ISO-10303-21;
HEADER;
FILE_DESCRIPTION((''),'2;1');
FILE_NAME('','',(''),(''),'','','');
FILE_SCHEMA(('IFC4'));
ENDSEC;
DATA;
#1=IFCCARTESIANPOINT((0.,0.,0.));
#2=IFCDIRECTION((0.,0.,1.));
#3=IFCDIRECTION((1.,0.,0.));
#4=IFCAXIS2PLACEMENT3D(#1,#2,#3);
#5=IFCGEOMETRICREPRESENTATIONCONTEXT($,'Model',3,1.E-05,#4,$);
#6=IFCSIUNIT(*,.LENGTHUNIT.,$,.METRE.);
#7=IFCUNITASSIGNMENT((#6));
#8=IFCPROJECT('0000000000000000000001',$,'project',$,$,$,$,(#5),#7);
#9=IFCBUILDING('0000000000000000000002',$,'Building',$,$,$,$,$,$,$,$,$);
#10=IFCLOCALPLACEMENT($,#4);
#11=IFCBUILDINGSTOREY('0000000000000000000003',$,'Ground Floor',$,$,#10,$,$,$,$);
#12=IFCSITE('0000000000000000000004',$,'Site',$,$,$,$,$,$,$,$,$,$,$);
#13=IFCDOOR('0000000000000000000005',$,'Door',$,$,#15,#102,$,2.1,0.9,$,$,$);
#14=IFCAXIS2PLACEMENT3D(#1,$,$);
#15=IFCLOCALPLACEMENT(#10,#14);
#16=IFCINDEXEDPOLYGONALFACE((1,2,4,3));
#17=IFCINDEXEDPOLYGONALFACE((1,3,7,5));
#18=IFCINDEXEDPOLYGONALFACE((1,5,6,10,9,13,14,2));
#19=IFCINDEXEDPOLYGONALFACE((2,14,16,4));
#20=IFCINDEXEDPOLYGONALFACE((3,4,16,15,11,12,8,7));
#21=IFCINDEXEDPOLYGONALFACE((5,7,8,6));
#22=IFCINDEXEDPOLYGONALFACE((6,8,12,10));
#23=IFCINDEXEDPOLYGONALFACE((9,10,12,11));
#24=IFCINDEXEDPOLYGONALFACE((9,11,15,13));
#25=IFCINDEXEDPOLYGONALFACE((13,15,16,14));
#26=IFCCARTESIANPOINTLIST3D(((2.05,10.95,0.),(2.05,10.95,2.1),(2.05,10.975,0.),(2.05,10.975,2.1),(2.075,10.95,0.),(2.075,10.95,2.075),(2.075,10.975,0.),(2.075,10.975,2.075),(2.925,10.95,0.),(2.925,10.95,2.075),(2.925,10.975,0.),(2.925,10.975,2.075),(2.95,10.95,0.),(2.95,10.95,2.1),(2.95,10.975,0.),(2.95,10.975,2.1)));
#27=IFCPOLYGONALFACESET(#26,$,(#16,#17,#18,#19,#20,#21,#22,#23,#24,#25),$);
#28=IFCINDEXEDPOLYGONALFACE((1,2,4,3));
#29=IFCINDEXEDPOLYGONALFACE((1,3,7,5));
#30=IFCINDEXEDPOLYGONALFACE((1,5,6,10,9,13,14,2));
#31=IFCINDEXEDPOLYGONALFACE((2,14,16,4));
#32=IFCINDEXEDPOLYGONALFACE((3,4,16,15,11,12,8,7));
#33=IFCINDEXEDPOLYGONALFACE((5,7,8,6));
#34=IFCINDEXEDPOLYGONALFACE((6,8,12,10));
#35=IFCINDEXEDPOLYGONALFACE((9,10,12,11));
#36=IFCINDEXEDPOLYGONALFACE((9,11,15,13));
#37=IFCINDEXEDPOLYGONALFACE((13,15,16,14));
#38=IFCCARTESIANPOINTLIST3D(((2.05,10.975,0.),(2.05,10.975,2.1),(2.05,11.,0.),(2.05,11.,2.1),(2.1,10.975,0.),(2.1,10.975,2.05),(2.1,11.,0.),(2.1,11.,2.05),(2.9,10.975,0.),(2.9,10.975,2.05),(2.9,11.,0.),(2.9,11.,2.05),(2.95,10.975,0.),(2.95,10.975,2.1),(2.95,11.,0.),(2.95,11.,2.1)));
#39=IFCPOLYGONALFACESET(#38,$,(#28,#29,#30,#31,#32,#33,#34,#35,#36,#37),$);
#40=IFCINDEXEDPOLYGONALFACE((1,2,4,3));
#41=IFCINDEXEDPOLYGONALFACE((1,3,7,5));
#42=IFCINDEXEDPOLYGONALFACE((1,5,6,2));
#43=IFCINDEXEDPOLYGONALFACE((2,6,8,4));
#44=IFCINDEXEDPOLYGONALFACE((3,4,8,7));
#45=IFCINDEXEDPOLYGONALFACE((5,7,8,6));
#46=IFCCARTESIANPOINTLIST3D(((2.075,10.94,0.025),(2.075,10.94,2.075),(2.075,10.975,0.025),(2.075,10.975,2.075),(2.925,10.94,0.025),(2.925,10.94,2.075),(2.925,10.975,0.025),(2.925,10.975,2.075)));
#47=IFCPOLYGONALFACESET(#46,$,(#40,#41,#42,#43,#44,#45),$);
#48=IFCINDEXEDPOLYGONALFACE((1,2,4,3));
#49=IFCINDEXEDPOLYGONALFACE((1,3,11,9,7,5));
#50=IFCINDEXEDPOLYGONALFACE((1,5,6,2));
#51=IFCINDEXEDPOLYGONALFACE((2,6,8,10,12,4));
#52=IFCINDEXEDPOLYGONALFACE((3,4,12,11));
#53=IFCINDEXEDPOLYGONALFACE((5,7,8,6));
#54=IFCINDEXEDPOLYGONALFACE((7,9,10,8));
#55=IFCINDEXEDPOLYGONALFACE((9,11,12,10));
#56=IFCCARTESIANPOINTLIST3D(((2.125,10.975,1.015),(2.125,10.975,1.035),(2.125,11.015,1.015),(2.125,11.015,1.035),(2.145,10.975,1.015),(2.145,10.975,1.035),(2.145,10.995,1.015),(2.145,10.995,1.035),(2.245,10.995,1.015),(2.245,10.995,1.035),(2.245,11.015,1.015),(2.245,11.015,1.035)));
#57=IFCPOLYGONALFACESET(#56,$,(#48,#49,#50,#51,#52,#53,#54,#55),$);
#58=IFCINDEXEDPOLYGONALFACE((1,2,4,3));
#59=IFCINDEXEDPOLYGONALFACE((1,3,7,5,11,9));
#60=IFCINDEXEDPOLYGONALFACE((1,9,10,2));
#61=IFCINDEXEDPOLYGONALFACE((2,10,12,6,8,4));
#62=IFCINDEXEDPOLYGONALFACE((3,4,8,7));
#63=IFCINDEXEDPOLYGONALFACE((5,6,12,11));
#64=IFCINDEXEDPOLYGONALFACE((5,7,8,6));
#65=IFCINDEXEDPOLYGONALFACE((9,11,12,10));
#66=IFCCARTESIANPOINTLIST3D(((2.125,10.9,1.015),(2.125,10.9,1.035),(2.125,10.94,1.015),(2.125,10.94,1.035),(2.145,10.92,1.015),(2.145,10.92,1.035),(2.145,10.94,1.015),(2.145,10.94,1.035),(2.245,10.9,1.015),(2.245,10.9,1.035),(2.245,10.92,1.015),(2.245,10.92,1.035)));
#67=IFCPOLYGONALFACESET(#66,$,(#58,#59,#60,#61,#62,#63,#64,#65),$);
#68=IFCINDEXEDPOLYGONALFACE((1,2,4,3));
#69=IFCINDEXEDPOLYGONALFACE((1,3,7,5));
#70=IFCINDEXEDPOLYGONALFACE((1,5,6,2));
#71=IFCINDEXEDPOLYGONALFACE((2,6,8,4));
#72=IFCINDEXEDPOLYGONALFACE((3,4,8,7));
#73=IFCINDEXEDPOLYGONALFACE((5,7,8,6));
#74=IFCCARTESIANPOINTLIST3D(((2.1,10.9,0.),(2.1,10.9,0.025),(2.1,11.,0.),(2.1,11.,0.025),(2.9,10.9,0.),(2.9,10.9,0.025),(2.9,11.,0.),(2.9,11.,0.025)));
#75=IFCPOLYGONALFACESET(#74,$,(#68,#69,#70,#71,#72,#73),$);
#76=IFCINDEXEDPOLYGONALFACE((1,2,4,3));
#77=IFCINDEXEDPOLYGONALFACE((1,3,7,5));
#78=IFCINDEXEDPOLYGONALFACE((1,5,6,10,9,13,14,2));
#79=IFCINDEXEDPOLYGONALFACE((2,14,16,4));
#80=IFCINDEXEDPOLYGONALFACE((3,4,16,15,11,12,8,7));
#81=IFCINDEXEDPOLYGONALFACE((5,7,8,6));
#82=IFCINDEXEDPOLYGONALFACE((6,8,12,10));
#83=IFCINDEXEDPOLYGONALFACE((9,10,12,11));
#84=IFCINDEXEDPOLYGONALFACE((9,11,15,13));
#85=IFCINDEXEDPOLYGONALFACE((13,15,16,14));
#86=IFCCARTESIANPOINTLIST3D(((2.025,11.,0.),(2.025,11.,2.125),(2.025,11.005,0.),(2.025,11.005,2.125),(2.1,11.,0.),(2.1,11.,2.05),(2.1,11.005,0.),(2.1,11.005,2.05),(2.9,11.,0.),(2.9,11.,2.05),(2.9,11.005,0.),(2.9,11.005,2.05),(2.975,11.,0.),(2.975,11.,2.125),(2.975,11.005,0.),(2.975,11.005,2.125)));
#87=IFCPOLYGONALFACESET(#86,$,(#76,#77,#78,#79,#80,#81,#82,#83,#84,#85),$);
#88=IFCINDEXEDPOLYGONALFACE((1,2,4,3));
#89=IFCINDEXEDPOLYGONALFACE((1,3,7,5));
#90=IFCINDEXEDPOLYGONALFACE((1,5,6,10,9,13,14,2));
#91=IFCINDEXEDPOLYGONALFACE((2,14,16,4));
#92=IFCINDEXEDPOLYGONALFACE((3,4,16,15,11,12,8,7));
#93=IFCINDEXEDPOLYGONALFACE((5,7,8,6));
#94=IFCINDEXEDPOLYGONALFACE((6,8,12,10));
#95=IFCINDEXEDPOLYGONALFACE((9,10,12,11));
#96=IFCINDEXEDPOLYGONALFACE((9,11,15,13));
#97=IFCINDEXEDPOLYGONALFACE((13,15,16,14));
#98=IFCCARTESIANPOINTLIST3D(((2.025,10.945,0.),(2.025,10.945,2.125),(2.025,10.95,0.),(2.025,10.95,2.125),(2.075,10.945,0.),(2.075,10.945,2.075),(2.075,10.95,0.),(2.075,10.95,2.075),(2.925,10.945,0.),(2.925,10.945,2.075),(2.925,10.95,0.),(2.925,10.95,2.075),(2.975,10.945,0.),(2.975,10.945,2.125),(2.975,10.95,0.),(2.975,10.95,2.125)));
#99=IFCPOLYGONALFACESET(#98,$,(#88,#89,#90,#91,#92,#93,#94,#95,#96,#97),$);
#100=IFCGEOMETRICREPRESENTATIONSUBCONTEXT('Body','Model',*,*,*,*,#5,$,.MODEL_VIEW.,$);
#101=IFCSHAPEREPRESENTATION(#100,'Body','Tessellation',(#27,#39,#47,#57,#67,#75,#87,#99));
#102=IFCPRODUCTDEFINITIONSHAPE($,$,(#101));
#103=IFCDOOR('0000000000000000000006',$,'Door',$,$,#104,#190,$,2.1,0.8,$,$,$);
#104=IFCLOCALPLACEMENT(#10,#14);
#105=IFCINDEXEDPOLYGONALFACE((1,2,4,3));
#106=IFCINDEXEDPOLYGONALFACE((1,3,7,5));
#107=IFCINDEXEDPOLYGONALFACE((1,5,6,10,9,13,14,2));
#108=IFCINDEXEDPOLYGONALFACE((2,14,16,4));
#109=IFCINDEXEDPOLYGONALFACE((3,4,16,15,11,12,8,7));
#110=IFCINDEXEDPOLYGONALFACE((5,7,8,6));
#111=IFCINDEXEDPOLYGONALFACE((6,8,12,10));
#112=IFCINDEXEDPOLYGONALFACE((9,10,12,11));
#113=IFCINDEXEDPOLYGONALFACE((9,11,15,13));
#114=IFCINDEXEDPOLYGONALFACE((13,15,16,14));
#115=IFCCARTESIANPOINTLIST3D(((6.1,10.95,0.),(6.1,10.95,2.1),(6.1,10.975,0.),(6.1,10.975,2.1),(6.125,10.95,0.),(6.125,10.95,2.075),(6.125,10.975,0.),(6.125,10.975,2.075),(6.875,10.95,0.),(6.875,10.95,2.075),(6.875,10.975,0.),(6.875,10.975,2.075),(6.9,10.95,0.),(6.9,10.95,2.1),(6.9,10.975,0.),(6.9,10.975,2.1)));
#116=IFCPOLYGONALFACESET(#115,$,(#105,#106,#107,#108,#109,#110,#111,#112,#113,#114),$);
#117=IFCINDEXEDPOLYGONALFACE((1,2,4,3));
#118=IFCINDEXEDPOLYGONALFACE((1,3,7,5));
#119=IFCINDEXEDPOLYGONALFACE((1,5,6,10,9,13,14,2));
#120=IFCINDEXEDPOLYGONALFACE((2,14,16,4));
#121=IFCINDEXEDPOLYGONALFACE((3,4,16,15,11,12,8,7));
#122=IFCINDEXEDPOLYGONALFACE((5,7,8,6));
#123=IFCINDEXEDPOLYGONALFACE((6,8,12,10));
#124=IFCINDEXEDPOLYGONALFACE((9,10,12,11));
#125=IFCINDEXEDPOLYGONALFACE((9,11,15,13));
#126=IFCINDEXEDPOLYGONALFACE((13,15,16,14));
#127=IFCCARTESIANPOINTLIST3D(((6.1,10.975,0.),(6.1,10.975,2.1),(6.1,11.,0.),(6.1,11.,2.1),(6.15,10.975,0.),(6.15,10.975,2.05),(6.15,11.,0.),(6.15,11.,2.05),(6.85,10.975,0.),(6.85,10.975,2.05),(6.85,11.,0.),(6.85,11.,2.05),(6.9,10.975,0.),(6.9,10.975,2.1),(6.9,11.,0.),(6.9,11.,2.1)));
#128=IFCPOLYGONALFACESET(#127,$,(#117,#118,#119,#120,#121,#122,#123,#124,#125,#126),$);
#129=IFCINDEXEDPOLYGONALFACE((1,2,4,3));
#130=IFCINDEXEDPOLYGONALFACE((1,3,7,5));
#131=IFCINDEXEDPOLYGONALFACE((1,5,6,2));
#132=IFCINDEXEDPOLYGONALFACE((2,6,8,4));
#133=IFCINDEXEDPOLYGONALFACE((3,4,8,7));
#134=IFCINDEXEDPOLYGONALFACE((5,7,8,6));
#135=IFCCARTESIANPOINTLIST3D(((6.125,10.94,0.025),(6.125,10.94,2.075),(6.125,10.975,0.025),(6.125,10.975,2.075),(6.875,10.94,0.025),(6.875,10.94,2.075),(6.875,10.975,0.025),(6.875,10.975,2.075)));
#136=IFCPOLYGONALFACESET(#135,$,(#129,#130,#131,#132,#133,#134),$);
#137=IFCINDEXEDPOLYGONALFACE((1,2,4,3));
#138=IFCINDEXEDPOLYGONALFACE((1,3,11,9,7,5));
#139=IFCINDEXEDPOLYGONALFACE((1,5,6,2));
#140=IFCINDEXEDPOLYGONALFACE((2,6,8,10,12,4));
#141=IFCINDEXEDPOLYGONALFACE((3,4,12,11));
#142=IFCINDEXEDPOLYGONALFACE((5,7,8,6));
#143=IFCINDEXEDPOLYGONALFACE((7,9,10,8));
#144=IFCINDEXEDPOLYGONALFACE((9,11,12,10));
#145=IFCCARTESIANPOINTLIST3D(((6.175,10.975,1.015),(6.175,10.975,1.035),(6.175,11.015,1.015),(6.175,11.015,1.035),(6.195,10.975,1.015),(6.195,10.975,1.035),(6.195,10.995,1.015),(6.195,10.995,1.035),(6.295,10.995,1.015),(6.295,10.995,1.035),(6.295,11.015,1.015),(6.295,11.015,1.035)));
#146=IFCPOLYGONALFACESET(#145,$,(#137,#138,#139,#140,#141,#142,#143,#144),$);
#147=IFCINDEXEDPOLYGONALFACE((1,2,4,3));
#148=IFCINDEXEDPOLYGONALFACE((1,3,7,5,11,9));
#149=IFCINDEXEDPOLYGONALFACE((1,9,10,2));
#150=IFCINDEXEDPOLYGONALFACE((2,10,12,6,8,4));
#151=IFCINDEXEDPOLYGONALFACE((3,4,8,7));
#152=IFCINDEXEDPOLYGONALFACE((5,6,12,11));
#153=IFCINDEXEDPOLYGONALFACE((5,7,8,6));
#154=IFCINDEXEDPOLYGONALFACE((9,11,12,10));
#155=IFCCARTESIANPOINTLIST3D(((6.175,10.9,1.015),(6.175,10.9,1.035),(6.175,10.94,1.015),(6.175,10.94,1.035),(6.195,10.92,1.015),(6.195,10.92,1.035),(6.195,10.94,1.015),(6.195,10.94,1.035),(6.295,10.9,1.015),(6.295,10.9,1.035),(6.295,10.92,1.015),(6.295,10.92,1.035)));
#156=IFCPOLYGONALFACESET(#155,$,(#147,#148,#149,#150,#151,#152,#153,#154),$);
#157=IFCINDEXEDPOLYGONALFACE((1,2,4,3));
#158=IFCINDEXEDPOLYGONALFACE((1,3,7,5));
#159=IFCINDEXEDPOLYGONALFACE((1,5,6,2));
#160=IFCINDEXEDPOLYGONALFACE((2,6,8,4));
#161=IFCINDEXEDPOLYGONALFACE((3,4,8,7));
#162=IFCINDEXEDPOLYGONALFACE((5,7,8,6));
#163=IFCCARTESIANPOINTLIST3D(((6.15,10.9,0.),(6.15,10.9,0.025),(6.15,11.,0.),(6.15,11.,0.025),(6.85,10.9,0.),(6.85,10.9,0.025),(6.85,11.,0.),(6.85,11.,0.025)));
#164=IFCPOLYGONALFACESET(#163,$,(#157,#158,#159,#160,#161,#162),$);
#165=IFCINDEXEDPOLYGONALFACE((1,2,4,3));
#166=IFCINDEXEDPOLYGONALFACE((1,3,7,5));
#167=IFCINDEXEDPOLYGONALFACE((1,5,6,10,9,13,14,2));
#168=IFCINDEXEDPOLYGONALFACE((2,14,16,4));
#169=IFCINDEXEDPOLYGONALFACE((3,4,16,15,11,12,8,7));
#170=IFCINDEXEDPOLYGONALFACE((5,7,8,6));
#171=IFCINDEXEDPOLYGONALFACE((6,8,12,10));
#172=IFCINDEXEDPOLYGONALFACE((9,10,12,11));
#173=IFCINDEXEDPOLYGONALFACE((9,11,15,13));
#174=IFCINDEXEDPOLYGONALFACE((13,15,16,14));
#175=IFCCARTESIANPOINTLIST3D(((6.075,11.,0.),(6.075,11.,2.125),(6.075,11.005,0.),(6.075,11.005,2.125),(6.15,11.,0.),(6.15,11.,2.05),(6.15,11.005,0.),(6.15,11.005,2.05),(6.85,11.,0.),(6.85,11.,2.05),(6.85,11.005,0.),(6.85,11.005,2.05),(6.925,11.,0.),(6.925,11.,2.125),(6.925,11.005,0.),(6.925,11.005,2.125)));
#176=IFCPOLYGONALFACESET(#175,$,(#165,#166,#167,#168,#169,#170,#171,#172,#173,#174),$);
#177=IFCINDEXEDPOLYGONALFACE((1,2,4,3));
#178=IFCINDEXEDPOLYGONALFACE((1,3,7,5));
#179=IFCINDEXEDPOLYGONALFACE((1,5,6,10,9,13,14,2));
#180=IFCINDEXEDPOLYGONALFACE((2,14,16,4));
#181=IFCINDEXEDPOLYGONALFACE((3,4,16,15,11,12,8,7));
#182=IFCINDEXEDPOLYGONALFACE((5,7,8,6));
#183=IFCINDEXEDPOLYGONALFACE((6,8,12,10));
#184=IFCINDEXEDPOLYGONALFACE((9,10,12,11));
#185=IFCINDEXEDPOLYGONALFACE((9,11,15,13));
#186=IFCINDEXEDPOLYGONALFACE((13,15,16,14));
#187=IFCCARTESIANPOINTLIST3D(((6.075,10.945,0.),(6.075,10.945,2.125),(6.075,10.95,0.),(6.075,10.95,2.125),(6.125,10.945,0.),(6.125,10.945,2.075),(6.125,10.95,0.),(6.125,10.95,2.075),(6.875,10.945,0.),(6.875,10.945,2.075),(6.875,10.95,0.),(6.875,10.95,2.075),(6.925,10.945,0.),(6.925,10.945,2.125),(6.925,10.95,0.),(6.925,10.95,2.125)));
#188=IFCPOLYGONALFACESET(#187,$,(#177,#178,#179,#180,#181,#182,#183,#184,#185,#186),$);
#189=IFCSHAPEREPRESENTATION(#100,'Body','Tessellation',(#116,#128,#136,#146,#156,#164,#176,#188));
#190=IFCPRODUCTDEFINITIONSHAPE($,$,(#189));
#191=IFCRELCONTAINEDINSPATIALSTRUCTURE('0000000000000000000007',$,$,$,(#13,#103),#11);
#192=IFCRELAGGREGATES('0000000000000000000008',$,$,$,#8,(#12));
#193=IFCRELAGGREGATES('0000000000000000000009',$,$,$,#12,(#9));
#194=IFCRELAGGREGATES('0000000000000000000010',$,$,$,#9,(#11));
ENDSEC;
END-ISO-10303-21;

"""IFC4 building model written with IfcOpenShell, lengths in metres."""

from ifc_helpers import new_model, si_unit, frame, origin_with_axes, place, context, subcontext, project, spatial, line, indexed_curve, outline, extrude, element, save


model = new_model("IFC4")

# Units and contexts
model_context = context("Model", 3, precision=1e-05, world=origin_with_axes())
body_context = subcontext(model_context, "Body", "Model", "MODEL_VIEW")
ifc_project = project(units=[si_unit("LENGTHUNIT", "METRE")], contexts=[model_context])

# Site, building, storey
site = spatial("IfcSite", under=ifc_project, Name="Site")
building = spatial("IfcBuilding", under=site, Name="Building")
storey_placement = place(None, origin_with_axes())
storey = spatial("IfcBuildingStorey", under=building, at=storey_placement, Name="Ground Floor")

# Doors
door_1_placement = place(storey_placement, frame((2.95, 11.0, 0.0), z_axis=(0.0, 0.0, 1.0), x_axis=(-1.0, 0.0, 0.0)))
element("IfcDoor", 1, at=door_1_placement, inside=storey, Name="Door", OverallHeight=2.1, OverallWidth=0.9, context=body_context, shape_type="SweptSolid", body=[
    extrude(outline(indexed_curve([(0.0, 0.0), (0.0, 2.1), (0.9, 2.1), (0.9, 0.0), (0.875, 0.0), (0.875, 2.075), (0.025, 2.075), (0.025, 0.0)], segments=[line(1, 2, 3, 4, 5, 6, 7, 8, 1)])), frame((0.0, 0.025, 0.0), z_axis=(0.0, -1.0, 0.0), x_axis=(1.0, 0.0, 0.0)), (0.0, 0.0, -1.0), 0.025),
    extrude(outline(indexed_curve([(0.0, 0.0), (0.0, 2.1), (0.9, 2.1), (0.9, 0.0), (0.85, 0.0), (0.85, 2.05), (0.05, 2.05), (0.05, 0.0)], segments=[line(1, 2, 3, 4, 5, 6, 7, 8, 1)])), frame((0.0, 0.0, 0.0), z_axis=(0.0, -1.0, 0.0), x_axis=(1.0, 0.0, 0.0)), (0.0, 0.0, -1.0), 0.025),
    extrude(outline(indexed_curve([(0.0, 0.0), (0.85, 0.0), (0.85, 0.035), (0.0, 0.035)], segments=[line(1, 2, 3, 4, 1)])), frame((0.025, 0.025, 0.025), z_axis=(0.0, 0.0, 1.0), x_axis=(1.0, 0.0, 0.0)), (0.0, 0.0, 1.0), 2.05),
    extrude(outline(indexed_curve([(0.0, 0.0), (0.0, -0.04), (-0.12, -0.04), (-0.12, -0.02), (-0.02, -0.02), (-0.02, 0.0)], segments=[line(1, 2, 3, 4, 5, 6, 1)])), frame((0.825, 0.025, 1.015), z_axis=(0.0, 0.0, 1.0), x_axis=(1.0, 0.0, 0.0)), (0.0, 0.0, 1.0), 0.02),
    extrude(outline(indexed_curve([(0.0, 0.0), (0.0, 0.04), (-0.12, 0.04), (-0.12, 0.02), (-0.02, 0.02), (-0.02, 0.0)], segments=[line(1, 2, 3, 4, 5, 6, 1)])), frame((0.825, 0.06, 1.015), z_axis=(0.0, 0.0, 1.0), x_axis=(1.0, 0.0, 0.0)), (0.0, 0.0, 1.0), 0.02),
    extrude(outline(indexed_curve([(0.0, 0.0), (0.8, 0.0), (0.8, 0.1), (0.0, 0.1)], segments=[line(1, 2, 3, 4, 1)])), frame((0.05, 0.0, 0.0), z_axis=(0.0, 0.0, 1.0), x_axis=(1.0, 0.0, 0.0)), (0.0, 0.0, 1.0), 0.025),
    extrude(outline(indexed_curve([(0.0, 0.0), (0.0, 2.125), (0.95, 2.125), (0.95, 0.0), (0.875, 0.0), (0.875, 2.05), (0.075, 2.05), (0.075, 0.0)], segments=[line(1, 2, 3, 4, 5, 6, 7, 8, 1)])), frame((-0.025, -0.005, 0.0), z_axis=(0.0, -1.0, 0.0), x_axis=(1.0, 0.0, 0.0)), (0.0, 0.0, -1.0), 0.005),
    extrude(outline(indexed_curve([(0.0, 0.0), (0.0, 2.125), (0.95, 2.125), (0.95, 0.0), (0.9, 0.0), (0.9, 2.075), (0.05, 2.075), (0.05, 0.0)], segments=[line(1, 2, 3, 4, 5, 6, 7, 8, 1)])), frame((-0.025, 0.05, 0.0), z_axis=(0.0, -1.0, 0.0), x_axis=(1.0, 0.0, 0.0)), (0.0, 0.0, -1.0), 0.005),
])
door_2_placement = place(storey_placement, frame((6.9, 11.0, 0.0), z_axis=(0.0, 0.0, 1.0), x_axis=(-1.0, 0.0, 0.0)))
element("IfcDoor", 2, at=door_2_placement, inside=storey, Name="Door", OverallHeight=2.1, OverallWidth=0.8, context=body_context, shape_type="SweptSolid", body=[
    extrude(outline(indexed_curve([(0.0, 0.0), (0.0, 2.1), (0.8, 2.1), (0.8, 0.0), (0.775, 0.0), (0.775, 2.075), (0.025, 2.075), (0.025, 0.0)], segments=[line(1, 2, 3, 4, 5, 6, 7, 8, 1)])), frame((0.0, 0.025, 0.0), z_axis=(0.0, -1.0, 0.0), x_axis=(1.0, 0.0, 0.0)), (0.0, 0.0, -1.0), 0.025),
    extrude(outline(indexed_curve([(0.0, 0.0), (0.0, 2.1), (0.8, 2.1), (0.8, 0.0), (0.75, 0.0), (0.75, 2.05), (0.05, 2.05), (0.05, 0.0)], segments=[line(1, 2, 3, 4, 5, 6, 7, 8, 1)])), frame((0.0, 0.0, 0.0), z_axis=(0.0, -1.0, 0.0), x_axis=(1.0, 0.0, 0.0)), (0.0, 0.0, -1.0), 0.025),
    extrude(outline(indexed_curve([(0.0, 0.0), (0.75, 0.0), (0.75, 0.035), (0.0, 0.035)], segments=[line(1, 2, 3, 4, 1)])), frame((0.025, 0.025, 0.025), z_axis=(0.0, 0.0, 1.0), x_axis=(1.0, 0.0, 0.0)), (0.0, 0.0, 1.0), 2.05),
    extrude(outline(indexed_curve([(0.0, 0.0), (0.0, -0.04), (-0.12, -0.04), (-0.12, -0.02), (-0.02, -0.02), (-0.02, 0.0)], segments=[line(1, 2, 3, 4, 5, 6, 1)])), frame((0.725, 0.025, 1.015), z_axis=(0.0, 0.0, 1.0), x_axis=(1.0, 0.0, 0.0)), (0.0, 0.0, 1.0), 0.02),
    extrude(outline(indexed_curve([(0.0, 0.0), (0.0, 0.04), (-0.12, 0.04), (-0.12, 0.02), (-0.02, 0.02), (-0.02, 0.0)], segments=[line(1, 2, 3, 4, 5, 6, 1)])), frame((0.725, 0.06, 1.015), z_axis=(0.0, 0.0, 1.0), x_axis=(1.0, 0.0, 0.0)), (0.0, 0.0, 1.0), 0.02),
    extrude(outline(indexed_curve([(0.0, 0.0), (0.7, 0.0), (0.7, 0.1), (0.0, 0.1)], segments=[line(1, 2, 3, 4, 1)])), frame((0.05, 0.0, 0.0), z_axis=(0.0, 0.0, 1.0), x_axis=(1.0, 0.0, 0.0)), (0.0, 0.0, 1.0), 0.025),
    extrude(outline(indexed_curve([(0.0, 0.0), (0.0, 2.125), (0.85, 2.125), (0.85, 0.0), (0.775, 0.0), (0.775, 2.05), (0.075, 2.05), (0.075, 0.0)], segments=[line(1, 2, 3, 4, 5, 6, 7, 8, 1)])), frame((-0.025, -0.005, 0.0), z_axis=(0.0, -1.0, 0.0), x_axis=(1.0, 0.0, 0.0)), (0.0, 0.0, -1.0), 0.005),
    extrude(outline(indexed_curve([(0.0, 0.0), (0.0, 2.125), (0.85, 2.125), (0.85, 0.0), (0.8, 0.0), (0.8, 2.075), (0.05, 2.075), (0.05, 0.0)], segments=[line(1, 2, 3, 4, 5, 6, 7, 8, 1)])), frame((-0.025, 0.05, 0.0), z_axis=(0.0, -1.0, 0.0), x_axis=(1.0, 0.0, 0.0)), (0.0, 0.0, -1.0), 0.005),
])

save(model, "model.ifc")
